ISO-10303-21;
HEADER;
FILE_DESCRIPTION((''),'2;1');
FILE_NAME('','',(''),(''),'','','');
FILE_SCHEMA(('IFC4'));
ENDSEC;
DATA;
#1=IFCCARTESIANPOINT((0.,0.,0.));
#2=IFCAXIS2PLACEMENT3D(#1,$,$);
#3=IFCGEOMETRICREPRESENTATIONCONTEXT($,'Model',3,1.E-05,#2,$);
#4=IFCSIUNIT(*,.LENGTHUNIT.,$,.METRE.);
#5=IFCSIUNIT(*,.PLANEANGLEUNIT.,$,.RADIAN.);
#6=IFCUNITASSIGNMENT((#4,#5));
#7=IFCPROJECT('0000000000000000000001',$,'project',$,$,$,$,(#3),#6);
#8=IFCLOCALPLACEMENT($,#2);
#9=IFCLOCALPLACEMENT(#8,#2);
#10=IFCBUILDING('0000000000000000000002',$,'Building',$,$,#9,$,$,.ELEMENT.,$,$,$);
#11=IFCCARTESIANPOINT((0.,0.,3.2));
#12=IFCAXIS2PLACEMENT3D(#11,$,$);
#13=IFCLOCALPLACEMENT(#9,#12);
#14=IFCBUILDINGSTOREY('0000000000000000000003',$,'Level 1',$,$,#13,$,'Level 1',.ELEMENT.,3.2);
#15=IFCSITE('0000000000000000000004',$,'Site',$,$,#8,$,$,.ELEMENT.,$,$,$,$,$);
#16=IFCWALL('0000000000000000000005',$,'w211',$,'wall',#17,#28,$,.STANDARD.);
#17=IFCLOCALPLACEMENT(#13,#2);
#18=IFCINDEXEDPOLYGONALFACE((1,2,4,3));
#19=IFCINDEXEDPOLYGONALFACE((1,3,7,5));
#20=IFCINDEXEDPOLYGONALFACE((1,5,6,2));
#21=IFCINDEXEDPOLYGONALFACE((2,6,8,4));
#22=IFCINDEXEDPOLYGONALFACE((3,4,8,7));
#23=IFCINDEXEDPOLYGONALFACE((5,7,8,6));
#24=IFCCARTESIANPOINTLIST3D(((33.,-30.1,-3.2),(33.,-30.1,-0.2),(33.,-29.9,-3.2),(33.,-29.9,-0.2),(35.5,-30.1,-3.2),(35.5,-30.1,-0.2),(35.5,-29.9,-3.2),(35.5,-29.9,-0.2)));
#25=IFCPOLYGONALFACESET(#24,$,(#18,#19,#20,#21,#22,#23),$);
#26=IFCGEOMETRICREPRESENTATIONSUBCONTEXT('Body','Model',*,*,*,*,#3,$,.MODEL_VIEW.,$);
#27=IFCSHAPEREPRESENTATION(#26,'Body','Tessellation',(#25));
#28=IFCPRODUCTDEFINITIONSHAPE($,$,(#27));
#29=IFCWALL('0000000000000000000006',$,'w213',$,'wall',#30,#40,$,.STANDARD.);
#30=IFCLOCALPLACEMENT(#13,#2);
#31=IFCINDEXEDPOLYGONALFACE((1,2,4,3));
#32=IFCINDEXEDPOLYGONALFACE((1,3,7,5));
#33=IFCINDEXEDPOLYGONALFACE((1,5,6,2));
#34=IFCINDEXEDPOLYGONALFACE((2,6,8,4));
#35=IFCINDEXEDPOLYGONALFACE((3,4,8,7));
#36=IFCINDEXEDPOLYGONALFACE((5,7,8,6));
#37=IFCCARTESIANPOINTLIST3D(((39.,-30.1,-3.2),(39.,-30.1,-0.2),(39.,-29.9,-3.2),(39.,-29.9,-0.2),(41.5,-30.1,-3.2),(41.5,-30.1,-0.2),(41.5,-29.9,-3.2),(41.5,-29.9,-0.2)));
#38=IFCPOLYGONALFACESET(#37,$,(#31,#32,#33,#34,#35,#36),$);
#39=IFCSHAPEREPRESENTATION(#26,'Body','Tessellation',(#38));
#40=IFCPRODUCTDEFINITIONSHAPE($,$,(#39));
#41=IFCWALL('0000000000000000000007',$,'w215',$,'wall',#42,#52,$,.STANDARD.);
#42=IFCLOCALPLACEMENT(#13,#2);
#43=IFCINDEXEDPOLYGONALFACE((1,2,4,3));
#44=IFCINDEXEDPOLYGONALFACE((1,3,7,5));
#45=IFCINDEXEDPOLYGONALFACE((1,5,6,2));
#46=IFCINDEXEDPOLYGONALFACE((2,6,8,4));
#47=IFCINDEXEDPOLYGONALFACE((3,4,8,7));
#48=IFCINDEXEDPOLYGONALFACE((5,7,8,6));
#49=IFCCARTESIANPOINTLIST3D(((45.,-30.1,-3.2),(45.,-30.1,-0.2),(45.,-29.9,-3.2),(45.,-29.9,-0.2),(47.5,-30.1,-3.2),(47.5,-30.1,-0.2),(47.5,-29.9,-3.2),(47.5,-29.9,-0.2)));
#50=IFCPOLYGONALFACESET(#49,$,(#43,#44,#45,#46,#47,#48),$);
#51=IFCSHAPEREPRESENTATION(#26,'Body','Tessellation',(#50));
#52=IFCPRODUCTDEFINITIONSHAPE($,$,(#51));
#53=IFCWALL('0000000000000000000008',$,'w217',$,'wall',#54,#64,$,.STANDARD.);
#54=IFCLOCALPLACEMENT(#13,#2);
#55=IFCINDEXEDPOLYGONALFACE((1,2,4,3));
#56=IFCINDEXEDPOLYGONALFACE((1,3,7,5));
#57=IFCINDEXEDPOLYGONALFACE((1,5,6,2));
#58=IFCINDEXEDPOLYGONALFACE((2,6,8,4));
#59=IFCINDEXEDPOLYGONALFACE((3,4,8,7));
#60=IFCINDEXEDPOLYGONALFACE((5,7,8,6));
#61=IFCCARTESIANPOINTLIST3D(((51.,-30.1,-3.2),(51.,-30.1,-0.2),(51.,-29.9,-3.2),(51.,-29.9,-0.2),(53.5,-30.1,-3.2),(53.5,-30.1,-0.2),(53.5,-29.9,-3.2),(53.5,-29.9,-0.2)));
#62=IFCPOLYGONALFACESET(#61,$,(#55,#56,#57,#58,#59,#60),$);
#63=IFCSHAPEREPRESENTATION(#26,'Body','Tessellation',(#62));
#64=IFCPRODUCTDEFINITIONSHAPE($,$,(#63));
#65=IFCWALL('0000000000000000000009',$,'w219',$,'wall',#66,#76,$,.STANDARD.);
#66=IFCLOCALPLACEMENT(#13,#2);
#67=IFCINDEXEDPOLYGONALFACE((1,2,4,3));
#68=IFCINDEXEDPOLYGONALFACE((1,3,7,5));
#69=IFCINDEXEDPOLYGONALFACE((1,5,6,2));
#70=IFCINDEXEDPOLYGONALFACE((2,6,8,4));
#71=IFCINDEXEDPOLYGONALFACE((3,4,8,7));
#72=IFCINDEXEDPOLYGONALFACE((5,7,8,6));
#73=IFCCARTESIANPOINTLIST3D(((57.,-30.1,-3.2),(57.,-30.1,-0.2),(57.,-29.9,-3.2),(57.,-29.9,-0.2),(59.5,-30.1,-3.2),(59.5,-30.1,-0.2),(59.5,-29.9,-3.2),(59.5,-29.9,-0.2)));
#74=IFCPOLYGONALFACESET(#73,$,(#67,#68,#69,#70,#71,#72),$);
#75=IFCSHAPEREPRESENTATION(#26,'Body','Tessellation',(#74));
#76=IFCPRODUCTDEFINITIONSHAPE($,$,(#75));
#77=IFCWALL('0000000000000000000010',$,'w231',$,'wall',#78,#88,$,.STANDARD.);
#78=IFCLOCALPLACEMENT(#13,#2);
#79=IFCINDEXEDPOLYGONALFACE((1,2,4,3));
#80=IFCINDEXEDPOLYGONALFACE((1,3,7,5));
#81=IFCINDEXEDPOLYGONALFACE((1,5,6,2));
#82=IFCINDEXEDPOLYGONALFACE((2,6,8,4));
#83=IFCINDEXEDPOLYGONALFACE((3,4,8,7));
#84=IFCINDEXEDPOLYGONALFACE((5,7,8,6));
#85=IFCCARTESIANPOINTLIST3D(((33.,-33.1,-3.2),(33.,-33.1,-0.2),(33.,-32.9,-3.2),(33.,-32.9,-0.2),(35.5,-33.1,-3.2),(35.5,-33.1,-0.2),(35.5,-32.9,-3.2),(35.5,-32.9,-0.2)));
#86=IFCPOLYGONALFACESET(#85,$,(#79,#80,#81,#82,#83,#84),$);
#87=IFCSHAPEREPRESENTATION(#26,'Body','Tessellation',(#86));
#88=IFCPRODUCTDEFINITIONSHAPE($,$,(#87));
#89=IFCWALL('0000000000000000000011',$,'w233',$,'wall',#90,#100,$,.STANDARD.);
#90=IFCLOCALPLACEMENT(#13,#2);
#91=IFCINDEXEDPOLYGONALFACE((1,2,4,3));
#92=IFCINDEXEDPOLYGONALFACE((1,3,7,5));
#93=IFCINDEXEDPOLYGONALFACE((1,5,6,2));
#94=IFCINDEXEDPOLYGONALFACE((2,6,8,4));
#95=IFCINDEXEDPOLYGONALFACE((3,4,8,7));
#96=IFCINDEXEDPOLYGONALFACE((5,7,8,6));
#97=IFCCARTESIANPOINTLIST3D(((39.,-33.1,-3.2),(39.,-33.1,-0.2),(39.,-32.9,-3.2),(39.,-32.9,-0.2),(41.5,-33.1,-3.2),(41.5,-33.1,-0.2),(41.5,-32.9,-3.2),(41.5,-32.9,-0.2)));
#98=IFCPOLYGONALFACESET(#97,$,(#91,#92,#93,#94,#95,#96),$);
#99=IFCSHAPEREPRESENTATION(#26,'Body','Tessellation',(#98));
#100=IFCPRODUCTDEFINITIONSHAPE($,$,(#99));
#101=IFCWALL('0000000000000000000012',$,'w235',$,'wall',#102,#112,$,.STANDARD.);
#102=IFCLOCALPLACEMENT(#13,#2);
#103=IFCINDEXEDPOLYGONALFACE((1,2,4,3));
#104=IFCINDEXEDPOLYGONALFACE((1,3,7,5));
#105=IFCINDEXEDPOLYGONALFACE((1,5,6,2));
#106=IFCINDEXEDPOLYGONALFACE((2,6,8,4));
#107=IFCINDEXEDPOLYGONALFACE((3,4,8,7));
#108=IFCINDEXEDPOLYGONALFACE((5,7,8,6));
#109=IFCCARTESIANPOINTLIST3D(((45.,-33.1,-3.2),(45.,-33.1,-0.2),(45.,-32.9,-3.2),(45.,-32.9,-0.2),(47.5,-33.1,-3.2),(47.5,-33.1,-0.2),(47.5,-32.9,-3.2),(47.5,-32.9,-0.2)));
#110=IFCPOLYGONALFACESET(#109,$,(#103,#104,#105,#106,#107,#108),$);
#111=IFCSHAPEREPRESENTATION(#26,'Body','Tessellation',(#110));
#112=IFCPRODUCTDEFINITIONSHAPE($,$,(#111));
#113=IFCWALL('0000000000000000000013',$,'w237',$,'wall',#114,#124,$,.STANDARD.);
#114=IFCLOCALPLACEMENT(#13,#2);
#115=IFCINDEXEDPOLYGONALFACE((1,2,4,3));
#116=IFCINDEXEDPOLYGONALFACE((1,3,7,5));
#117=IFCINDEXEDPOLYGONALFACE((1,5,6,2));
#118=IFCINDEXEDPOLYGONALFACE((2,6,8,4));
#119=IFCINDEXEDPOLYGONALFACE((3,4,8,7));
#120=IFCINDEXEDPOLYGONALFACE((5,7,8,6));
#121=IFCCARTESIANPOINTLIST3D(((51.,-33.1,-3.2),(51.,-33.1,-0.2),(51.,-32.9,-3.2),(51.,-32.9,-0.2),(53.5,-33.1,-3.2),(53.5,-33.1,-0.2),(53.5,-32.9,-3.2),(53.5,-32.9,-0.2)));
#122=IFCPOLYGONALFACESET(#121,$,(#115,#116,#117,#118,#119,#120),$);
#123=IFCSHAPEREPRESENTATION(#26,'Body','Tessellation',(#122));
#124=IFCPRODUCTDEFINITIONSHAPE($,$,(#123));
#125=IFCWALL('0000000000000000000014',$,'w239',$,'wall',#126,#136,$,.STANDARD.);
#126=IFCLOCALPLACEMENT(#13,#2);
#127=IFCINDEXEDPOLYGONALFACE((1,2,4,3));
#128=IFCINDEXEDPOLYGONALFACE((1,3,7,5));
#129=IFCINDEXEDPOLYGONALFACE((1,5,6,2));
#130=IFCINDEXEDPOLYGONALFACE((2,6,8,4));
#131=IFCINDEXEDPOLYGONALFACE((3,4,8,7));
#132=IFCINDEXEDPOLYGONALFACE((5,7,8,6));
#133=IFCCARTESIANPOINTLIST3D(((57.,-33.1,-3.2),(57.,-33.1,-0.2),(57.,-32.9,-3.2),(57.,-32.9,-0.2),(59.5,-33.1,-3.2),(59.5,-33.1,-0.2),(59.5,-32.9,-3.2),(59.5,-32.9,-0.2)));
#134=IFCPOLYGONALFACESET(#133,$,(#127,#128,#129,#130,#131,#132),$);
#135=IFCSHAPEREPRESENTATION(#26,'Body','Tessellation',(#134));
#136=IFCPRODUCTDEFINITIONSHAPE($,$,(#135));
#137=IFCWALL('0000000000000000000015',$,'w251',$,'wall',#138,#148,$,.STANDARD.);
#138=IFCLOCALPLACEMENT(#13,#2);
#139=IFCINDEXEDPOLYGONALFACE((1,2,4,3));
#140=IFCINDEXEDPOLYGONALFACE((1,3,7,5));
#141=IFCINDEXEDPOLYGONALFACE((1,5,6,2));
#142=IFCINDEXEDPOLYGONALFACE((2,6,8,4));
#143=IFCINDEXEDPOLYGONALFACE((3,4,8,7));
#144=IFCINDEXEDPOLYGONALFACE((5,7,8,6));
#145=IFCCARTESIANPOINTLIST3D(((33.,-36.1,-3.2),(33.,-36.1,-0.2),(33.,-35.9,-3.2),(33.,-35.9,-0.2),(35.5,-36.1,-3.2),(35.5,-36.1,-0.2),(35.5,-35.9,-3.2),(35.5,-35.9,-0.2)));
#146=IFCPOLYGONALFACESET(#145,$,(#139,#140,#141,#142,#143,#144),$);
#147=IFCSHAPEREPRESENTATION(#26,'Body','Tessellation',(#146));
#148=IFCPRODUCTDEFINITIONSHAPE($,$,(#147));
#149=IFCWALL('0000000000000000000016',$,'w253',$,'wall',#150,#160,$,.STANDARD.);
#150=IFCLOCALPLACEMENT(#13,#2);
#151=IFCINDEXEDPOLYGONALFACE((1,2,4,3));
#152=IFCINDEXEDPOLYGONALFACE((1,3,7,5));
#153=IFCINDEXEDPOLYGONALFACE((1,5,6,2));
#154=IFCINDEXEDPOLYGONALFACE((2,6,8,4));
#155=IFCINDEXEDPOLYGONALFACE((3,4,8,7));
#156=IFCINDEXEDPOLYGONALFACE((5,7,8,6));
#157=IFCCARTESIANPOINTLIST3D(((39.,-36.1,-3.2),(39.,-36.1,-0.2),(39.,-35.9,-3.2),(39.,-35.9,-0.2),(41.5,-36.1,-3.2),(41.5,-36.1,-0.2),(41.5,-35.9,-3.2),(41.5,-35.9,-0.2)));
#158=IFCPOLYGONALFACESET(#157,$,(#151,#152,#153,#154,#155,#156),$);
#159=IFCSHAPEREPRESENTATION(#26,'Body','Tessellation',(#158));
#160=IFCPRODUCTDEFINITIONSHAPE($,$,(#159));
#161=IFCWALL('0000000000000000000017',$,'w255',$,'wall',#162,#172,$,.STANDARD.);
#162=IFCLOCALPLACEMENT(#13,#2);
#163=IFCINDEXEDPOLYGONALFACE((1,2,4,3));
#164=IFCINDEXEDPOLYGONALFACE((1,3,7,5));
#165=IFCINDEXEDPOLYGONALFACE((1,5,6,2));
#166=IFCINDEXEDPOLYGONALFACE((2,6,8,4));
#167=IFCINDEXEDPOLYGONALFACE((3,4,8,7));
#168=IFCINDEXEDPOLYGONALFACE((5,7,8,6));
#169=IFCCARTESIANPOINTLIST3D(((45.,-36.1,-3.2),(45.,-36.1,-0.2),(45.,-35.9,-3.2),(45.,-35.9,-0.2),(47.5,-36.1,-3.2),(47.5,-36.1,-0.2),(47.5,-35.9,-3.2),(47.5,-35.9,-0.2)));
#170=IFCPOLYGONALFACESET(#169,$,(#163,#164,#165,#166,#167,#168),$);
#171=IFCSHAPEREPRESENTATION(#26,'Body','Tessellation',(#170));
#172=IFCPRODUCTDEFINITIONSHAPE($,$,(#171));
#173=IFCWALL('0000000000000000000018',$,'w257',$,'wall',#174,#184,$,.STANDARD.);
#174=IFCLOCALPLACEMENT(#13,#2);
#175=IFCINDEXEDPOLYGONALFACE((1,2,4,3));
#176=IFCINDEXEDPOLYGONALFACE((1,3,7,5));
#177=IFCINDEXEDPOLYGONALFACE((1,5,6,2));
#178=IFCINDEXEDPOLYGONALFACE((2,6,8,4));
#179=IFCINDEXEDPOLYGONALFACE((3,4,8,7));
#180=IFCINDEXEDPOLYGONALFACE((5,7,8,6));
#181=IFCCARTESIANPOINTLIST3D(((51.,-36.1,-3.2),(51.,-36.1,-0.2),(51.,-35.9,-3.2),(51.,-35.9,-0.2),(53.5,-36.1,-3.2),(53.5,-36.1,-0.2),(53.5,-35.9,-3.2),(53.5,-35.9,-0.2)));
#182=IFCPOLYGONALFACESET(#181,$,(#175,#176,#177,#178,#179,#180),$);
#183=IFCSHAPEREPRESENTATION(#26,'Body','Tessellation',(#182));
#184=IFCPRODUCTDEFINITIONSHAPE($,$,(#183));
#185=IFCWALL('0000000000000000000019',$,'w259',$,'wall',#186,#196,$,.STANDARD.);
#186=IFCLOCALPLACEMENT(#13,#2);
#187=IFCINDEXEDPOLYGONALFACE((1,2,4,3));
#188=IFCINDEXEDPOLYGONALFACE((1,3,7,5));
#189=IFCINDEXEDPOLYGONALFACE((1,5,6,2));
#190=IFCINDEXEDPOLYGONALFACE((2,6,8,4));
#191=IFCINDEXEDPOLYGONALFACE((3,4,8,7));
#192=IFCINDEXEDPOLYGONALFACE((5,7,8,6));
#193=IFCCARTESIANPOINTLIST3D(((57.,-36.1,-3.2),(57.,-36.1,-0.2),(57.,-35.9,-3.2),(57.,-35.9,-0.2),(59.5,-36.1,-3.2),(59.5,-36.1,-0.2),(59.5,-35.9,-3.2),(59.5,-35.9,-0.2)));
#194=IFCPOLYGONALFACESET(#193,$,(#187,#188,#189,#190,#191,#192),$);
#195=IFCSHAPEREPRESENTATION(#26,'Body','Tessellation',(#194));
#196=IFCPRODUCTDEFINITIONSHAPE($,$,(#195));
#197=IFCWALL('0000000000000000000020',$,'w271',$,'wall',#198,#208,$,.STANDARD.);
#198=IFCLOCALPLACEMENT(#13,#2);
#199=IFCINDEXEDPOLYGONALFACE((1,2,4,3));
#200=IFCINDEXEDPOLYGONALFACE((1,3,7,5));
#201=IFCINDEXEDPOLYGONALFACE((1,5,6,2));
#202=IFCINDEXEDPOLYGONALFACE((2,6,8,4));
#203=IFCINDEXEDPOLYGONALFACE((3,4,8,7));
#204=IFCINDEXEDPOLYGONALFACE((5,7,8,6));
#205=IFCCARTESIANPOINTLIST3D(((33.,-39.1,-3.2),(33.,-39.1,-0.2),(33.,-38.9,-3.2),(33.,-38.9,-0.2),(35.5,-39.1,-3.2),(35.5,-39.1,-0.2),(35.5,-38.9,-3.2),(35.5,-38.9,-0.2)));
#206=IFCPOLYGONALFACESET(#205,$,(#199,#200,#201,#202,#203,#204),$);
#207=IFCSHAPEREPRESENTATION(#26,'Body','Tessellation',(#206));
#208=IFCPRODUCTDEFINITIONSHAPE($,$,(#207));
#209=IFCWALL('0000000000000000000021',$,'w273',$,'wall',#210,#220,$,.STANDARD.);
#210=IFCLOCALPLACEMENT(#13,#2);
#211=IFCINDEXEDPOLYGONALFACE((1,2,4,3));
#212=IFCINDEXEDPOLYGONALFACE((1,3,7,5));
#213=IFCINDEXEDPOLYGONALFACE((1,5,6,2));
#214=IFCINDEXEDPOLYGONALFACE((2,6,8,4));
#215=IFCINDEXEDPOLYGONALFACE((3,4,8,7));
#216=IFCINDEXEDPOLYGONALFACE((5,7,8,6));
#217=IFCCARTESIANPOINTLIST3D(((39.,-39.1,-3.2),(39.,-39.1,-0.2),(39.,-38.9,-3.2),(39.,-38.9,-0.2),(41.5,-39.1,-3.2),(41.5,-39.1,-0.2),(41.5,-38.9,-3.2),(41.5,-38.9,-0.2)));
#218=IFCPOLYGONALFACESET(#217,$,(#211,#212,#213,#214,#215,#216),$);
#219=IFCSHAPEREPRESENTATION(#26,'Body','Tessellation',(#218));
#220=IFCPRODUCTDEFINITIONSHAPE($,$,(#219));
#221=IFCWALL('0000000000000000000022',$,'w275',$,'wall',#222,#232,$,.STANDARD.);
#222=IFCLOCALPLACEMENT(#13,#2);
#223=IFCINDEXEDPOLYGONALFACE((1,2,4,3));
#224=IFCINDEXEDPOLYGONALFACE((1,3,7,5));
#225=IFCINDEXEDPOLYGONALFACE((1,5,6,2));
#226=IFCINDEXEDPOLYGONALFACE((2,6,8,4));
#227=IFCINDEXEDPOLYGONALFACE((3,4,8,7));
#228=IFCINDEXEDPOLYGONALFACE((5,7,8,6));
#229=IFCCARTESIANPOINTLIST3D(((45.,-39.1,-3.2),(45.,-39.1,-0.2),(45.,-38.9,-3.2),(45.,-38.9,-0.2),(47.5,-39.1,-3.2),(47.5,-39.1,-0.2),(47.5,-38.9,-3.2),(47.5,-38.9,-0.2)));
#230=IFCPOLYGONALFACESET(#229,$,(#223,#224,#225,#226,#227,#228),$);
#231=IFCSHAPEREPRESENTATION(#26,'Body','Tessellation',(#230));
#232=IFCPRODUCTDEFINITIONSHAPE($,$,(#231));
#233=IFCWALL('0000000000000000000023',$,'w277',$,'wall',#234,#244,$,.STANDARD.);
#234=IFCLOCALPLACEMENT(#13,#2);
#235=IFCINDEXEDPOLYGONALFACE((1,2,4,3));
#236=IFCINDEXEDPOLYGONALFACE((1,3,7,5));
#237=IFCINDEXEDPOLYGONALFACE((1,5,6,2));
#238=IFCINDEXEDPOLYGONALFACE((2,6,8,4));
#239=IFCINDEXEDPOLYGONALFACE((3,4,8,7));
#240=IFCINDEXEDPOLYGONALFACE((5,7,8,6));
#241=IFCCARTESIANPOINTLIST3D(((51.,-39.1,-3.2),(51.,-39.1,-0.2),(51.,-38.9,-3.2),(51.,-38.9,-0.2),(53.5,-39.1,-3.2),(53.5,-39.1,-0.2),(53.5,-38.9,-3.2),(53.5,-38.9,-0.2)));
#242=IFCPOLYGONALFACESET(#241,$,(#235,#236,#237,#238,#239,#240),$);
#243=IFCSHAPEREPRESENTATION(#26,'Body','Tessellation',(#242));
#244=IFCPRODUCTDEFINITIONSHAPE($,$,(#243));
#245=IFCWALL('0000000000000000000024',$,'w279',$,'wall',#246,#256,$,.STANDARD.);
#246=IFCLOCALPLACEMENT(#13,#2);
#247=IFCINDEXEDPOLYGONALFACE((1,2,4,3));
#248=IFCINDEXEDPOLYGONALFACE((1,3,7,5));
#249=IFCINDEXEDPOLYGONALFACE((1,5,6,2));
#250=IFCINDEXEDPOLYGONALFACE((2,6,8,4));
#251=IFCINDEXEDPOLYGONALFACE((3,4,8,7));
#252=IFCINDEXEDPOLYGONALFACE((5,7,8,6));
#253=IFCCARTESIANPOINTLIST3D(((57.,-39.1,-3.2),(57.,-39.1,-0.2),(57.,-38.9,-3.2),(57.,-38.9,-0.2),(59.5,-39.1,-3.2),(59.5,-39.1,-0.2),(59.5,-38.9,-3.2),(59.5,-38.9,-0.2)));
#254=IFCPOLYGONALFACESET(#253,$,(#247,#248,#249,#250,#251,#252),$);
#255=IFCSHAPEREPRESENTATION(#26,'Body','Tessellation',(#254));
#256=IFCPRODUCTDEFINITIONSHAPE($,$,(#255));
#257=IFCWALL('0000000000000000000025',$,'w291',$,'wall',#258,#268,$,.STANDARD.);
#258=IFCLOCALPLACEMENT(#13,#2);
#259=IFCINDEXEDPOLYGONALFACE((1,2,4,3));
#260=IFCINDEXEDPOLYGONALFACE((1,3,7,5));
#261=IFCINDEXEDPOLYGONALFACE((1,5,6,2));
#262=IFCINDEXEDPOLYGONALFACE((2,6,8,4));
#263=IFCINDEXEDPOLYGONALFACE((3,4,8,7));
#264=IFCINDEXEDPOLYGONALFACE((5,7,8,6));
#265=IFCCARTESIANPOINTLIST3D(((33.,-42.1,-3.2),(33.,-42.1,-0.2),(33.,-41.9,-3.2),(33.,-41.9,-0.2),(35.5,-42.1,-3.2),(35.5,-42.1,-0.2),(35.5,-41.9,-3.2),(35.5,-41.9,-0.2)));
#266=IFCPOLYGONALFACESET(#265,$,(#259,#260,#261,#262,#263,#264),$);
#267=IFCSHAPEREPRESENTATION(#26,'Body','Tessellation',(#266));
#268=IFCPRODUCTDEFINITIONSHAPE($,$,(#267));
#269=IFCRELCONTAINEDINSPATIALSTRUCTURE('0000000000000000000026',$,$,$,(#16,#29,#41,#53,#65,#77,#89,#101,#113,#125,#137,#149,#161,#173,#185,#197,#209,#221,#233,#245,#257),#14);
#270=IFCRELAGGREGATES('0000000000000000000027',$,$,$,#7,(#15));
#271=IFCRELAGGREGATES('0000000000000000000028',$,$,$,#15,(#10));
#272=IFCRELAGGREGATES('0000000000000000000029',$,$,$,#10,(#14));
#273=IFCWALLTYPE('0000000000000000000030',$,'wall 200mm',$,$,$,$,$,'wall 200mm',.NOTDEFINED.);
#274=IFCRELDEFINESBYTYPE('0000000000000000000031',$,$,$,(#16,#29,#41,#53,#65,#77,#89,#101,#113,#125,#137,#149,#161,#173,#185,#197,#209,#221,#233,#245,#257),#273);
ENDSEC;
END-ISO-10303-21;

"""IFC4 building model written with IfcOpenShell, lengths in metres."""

from ifc_helpers import new_model, si_unit, frame, frame_2d, origin, place, context, subcontext, project, spatial, rectangle, extrude, type_object, element, save


model = new_model("IFC4")

# Units and contexts
model_context = context("Model", 3, precision=1e-05, world=origin())
body_context = subcontext(model_context, "Body", "Model", "MODEL_VIEW")
ifc_project = project(units=[si_unit("LENGTHUNIT", "METRE"), si_unit("PLANEANGLEUNIT", "RADIAN")], contexts=[model_context])

# Site, building, storey
site_placement = place(None, origin())
site = spatial("IfcSite", under=ifc_project, at=site_placement, Name="Site", CompositionType="ELEMENT")
building_placement = place(site_placement, origin())
building = spatial("IfcBuilding", under=site, at=building_placement, Name="Building", CompositionType="ELEMENT")
storey_placement = place(building_placement, frame((0.0, 0.0, 3.2)))
storey = spatial("IfcBuildingStorey", under=building, at=storey_placement, Name="Level 1", LongName="Level 1", CompositionType="ELEMENT", Elevation=3.2)

# Walls
wall_type = type_object("IfcWallType", Name="wall 200mm", ElementType="wall 200mm", PredefinedType="NOTDEFINED")
for number, where, z_axis, x_axis, name in (
    (1, (33.0, -30.0, -3.2), (0.0, 0.0, 1.0), (1.0, 0.0, 0.0), "w211"),
    (2, (39.0, -30.0, -3.2), (0.0, 0.0, 1.0), (1.0, 0.0, 0.0), "w213"),
    (3, (45.0, -30.0, -3.2), (0.0, 0.0, 1.0), (1.0, 0.0, 0.0), "w215"),
    (4, (51.0, -30.0, -3.2), (0.0, 0.0, 1.0), (1.0, 0.0, 0.0), "w217"),
    (5, (57.0, -30.0, -3.2), (0.0, 0.0, 1.0), (1.0, 0.0, 0.0), "w219"),
    (6, (33.0, -33.0, -3.2), (0.0, 0.0, 1.0), (1.0, 0.0, 0.0), "w231"),
    (7, (39.0, -33.0, -3.2), (0.0, 0.0, 1.0), (1.0, 0.0, 0.0), "w233"),
    (8, (45.0, -33.0, -3.2), (0.0, 0.0, 1.0), (1.0, 0.0, 0.0), "w235"),
    (9, (51.0, -33.0, -3.2), (0.0, 0.0, 1.0), (1.0, 0.0, 0.0), "w237"),
    (10, (57.0, -33.0, -3.2), (0.0, 0.0, 1.0), (1.0, 0.0, 0.0), "w239"),
    (11, (33.0, -36.0, -3.2), (0.0, 0.0, 1.0), (1.0, 0.0, 0.0), "w251"),
    (12, (39.0, -36.0, -3.2), (0.0, 0.0, 1.0), (1.0, 0.0, 0.0), "w253"),
    (13, (45.0, -36.0, -3.2), (0.0, 0.0, 1.0), (1.0, 0.0, 0.0), "w255"),
    (14, (51.0, -36.0, -3.2), (0.0, 0.0, 1.0), (1.0, 0.0, 0.0), "w257"),
    (15, (57.0, -36.0, -3.2), (0.0, 0.0, 1.0), (1.0, 0.0, 0.0), "w259"),
    (16, (33.0, -39.0, -3.2), (0.0, 0.0, 1.0), (1.0, 0.0, 0.0), "w271"),
    (17, (39.0, -39.0, -3.2), (0.0, 0.0, 1.0), (1.0, 0.0, 0.0), "w273"),
    (18, (45.0, -39.0, -3.2), (0.0, 0.0, 1.0), (1.0, 0.0, 0.0), "w275"),
    (19, (51.0, -39.0, -3.2), (0.0, 0.0, 1.0), (1.0, 0.0, 0.0), "w277"),
    (20, (57.0, -39.0, -3.2), (0.0, 0.0, 1.0), (1.0, 0.0, 0.0), "w279"),
    (21, (33.0, -42.0, -3.2), (0.0, 0.0, 1.0), (1.0, 0.0, 0.0), "w291"),
):
    element("IfcWall", number, at=place(storey_placement, frame(where, z_axis=z_axis, x_axis=x_axis)), inside=storey, type_object=wall_type, Name=name, ObjectType="wall", PredefinedType="STANDARD", context=body_context, shape_type="SweptSolid", body=[
        extrude(rectangle(XDim=2.5, YDim=0.2, at=frame_2d((1.25, 0.0))), origin(), (0.0, 0.0, 1.0), 3.0),
    ])

save(model, "model.ifc")
